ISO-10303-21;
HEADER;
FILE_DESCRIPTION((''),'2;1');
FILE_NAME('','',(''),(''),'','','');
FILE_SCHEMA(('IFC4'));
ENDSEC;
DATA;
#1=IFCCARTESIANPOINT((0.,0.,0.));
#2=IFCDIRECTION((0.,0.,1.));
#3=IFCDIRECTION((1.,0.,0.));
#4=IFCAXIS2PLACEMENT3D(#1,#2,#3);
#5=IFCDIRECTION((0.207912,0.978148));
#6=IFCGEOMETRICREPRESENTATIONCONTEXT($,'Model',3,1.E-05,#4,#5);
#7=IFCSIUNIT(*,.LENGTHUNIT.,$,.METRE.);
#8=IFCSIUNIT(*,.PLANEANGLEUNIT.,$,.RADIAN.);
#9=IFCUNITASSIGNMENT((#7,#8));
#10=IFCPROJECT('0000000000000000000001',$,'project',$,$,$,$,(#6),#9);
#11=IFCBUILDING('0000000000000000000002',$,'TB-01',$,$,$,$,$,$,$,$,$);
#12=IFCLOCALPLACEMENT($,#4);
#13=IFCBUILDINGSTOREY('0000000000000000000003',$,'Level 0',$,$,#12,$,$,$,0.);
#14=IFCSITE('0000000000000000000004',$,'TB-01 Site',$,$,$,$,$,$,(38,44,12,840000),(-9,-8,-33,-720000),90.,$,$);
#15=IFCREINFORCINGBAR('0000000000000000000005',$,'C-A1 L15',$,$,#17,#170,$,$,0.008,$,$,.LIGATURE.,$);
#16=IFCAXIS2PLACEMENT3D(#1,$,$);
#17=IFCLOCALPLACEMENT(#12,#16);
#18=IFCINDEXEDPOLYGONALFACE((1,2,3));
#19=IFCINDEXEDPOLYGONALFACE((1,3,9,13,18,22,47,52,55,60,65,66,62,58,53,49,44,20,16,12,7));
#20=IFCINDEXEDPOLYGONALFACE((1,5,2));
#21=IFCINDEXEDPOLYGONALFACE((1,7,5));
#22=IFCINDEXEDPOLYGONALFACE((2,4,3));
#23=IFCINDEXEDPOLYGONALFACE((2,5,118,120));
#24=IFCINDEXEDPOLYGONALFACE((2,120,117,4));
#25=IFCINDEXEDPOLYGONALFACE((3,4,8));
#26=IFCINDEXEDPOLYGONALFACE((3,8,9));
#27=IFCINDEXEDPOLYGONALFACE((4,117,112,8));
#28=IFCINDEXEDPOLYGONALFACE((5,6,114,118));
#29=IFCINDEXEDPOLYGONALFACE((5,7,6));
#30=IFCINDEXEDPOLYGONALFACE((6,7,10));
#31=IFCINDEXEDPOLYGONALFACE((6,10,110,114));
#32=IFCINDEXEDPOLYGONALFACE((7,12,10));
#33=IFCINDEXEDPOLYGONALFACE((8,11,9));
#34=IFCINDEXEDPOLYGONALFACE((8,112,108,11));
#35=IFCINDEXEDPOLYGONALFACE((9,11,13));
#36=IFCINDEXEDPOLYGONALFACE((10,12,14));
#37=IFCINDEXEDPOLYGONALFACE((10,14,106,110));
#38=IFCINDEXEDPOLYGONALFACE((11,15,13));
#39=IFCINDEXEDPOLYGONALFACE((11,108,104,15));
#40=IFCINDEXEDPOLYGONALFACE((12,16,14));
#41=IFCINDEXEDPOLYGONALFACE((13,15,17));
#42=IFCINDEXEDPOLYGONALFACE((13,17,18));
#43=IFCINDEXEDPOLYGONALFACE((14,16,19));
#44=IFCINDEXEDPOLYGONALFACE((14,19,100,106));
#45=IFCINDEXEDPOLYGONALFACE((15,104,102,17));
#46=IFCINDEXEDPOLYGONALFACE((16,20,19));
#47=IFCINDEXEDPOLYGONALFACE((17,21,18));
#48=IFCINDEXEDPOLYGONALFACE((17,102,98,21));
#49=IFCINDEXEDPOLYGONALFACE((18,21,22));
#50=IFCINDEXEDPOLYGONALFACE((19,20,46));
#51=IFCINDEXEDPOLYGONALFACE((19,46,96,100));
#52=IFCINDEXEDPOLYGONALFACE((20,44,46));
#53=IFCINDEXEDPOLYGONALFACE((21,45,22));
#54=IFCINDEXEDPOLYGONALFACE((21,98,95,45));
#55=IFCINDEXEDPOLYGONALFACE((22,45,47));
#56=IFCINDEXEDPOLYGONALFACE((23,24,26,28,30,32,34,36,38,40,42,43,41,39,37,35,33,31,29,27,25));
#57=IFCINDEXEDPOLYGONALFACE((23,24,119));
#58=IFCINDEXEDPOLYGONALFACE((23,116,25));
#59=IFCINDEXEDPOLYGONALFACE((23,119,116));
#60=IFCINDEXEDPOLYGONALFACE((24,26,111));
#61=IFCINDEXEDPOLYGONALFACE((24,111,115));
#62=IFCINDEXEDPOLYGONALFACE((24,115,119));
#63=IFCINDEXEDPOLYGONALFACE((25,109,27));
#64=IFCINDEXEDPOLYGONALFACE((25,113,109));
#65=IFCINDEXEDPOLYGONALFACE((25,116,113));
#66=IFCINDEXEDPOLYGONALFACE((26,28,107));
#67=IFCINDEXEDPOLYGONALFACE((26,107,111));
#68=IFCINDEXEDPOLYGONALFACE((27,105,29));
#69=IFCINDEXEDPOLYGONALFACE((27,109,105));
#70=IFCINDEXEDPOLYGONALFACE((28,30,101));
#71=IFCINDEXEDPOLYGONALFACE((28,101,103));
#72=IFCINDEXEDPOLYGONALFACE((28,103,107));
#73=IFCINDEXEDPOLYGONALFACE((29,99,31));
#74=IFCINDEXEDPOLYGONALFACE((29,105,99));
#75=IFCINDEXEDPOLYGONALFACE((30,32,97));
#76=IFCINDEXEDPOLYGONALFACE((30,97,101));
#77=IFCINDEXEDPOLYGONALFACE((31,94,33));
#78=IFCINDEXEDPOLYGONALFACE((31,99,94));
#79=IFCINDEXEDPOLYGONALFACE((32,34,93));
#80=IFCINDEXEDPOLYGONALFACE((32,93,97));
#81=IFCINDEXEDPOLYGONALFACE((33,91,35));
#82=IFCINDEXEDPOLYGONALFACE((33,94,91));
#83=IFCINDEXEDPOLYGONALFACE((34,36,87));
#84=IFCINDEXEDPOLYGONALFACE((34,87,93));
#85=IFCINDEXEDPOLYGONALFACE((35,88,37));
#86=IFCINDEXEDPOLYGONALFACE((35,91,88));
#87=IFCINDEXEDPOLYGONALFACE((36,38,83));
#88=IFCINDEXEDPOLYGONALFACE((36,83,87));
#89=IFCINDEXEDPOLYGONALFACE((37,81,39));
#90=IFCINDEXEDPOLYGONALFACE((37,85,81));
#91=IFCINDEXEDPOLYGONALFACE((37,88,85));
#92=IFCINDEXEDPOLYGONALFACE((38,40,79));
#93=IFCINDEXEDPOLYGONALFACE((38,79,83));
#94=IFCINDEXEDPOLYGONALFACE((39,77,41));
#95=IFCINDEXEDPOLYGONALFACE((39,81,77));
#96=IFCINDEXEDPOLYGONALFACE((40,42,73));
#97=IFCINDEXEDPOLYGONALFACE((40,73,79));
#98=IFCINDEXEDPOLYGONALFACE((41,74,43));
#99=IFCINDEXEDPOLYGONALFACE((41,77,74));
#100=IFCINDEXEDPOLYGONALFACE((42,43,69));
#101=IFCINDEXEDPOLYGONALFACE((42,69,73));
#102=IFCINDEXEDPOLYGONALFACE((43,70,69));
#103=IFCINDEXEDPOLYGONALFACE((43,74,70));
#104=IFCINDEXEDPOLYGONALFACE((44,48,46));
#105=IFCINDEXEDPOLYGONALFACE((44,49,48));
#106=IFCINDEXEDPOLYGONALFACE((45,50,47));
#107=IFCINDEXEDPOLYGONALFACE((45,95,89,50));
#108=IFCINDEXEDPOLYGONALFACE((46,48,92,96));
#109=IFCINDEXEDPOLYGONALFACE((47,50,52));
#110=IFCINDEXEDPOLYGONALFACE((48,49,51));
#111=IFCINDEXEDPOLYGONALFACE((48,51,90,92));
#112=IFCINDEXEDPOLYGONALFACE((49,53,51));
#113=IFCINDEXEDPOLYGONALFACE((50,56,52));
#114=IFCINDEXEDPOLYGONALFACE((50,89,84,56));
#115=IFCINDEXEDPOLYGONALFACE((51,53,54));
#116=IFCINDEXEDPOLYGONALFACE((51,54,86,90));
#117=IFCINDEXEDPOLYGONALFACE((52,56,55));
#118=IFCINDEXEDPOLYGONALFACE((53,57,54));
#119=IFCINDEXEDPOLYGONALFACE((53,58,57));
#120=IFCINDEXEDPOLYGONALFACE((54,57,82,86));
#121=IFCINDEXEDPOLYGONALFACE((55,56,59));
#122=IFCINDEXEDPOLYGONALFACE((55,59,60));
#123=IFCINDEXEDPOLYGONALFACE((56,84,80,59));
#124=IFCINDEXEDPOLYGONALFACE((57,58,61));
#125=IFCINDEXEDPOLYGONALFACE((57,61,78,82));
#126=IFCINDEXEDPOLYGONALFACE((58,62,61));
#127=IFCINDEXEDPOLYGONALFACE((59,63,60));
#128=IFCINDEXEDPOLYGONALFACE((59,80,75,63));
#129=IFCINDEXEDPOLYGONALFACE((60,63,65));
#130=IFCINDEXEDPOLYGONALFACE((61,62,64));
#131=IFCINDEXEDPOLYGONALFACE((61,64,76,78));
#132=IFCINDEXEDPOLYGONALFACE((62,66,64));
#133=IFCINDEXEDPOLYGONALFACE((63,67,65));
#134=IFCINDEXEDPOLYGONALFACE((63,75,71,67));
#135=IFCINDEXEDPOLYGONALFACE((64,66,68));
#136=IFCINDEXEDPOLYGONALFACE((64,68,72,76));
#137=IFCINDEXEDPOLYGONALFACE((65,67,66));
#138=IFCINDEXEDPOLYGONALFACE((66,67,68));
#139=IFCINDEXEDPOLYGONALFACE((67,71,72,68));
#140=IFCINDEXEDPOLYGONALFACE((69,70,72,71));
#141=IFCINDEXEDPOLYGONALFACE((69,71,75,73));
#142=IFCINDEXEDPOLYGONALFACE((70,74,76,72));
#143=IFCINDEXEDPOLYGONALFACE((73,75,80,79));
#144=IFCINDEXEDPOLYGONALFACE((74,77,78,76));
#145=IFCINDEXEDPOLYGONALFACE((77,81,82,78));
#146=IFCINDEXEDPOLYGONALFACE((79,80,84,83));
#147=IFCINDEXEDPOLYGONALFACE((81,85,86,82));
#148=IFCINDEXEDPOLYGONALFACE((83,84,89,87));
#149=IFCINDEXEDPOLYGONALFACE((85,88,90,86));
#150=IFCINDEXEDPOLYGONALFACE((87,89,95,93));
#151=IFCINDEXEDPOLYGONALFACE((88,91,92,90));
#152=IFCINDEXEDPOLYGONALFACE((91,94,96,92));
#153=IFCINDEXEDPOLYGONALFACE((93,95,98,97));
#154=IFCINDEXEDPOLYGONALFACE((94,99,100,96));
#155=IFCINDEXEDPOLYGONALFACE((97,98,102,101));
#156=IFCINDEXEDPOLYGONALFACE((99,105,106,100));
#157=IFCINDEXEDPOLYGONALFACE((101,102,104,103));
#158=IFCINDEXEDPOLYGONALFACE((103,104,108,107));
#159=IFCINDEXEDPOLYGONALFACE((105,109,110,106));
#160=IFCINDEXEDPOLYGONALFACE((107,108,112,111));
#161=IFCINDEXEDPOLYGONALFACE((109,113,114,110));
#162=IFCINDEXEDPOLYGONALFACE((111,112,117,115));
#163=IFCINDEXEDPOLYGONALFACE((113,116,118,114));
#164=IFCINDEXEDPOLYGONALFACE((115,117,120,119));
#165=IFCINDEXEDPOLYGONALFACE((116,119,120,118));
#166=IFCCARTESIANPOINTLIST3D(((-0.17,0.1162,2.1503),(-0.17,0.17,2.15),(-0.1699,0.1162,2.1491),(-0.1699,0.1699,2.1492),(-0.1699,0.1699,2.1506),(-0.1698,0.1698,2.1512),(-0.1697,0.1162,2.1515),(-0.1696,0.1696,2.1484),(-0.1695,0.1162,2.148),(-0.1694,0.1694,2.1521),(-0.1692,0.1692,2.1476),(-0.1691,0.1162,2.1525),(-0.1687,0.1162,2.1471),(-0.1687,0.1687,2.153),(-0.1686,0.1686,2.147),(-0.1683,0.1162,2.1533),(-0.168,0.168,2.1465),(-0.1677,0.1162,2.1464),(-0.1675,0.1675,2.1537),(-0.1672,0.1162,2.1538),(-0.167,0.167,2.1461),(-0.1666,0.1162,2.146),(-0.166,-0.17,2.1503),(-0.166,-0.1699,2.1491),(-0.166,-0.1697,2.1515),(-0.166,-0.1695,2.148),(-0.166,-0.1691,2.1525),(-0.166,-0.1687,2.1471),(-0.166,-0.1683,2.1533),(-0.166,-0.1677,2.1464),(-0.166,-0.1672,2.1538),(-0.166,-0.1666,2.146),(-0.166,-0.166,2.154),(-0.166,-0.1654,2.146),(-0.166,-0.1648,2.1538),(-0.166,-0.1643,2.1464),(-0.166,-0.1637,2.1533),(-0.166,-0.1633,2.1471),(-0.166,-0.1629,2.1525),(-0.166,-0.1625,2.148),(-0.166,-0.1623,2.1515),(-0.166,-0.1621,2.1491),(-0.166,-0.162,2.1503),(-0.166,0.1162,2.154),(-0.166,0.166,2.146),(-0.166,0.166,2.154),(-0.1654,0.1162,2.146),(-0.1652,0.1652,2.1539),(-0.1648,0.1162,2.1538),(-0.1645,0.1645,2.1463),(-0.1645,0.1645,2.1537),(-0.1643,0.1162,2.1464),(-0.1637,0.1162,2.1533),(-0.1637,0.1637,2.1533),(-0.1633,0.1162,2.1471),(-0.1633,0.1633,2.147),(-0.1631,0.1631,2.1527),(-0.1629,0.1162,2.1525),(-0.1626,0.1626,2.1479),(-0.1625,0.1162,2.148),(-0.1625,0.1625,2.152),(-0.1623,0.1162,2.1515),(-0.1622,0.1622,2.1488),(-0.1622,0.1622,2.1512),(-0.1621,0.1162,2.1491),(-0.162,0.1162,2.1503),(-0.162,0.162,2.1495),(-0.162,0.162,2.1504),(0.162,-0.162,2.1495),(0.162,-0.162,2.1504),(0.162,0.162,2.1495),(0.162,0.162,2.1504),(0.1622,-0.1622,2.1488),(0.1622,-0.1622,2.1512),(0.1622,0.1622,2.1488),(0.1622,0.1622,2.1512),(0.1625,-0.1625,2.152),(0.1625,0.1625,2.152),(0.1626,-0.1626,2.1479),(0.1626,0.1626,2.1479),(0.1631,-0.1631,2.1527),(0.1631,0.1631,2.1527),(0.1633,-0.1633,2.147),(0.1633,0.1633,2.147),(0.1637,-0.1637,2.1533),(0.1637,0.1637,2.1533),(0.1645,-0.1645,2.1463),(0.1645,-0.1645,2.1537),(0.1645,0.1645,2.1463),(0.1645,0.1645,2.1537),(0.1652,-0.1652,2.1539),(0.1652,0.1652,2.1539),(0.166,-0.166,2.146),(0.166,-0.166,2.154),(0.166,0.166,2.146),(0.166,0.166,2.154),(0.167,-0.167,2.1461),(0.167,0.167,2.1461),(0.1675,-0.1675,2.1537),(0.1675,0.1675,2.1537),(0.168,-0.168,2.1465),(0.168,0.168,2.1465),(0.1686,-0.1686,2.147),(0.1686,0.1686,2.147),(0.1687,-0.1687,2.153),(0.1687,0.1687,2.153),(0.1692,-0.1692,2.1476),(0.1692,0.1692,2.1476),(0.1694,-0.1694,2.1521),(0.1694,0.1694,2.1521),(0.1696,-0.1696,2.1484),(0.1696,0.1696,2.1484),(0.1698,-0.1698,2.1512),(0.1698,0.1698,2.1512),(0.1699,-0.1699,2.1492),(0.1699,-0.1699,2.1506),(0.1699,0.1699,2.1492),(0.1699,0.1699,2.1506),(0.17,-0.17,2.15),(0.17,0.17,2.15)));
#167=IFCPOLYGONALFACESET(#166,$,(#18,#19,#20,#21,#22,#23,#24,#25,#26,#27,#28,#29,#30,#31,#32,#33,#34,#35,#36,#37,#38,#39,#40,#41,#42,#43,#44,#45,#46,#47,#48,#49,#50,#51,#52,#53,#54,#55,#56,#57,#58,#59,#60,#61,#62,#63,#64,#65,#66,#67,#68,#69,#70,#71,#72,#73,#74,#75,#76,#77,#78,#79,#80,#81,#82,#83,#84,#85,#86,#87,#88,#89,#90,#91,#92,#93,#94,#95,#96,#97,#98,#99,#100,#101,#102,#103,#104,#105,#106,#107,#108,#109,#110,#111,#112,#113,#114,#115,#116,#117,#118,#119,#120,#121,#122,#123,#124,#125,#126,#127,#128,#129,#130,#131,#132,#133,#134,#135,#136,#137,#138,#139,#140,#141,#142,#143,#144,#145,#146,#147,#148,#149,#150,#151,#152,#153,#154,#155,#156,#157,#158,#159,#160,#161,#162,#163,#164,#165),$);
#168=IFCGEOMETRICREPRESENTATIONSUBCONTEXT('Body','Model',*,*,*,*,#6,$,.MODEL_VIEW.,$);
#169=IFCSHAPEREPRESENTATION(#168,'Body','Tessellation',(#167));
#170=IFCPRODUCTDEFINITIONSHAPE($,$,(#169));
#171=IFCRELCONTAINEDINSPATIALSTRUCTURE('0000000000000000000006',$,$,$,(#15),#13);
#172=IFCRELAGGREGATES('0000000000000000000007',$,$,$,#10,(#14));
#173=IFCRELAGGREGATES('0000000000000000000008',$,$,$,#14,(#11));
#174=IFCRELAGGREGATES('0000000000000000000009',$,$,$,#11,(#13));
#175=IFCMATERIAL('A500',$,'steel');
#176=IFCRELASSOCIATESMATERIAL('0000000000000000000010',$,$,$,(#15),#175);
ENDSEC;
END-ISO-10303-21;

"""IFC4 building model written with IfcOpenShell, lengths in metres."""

from ifc_helpers import new_model, entity, si_unit, direction, origin_with_axes, place, context, subcontext, project, spatial, material, element, save


model = new_model("IFC4")

# Units and contexts
model_context = context("Model", 3, precision=1e-05, world=origin_with_axes(), true_north=direction((0.207912, 0.978148)))
body_context = subcontext(model_context, "Body", "Model", "MODEL_VIEW")
ifc_project = project(units=[si_unit("LENGTHUNIT", "METRE"), si_unit("PLANEANGLEUNIT", "RADIAN")], contexts=[model_context])

# Site, building, storey
site = spatial("IfcSite", under=ifc_project, Name="TB-01 Site", RefLatitude=(38, 44, 12, 840000), RefLongitude=(-9, -8, -33, -720000), RefElevation=90.0)
building = spatial("IfcBuilding", under=site, Name="TB-01")
storey_placement = place(None, origin_with_axes())
storey = spatial("IfcBuildingStorey", under=building, at=storey_placement, Name="Level 0", Elevation=0.0)

# Reinforcing bar
ifc_material_1 = material(Name="A500", Category="steel")
reinforcing_bar_1_placement = place(storey_placement, origin_with_axes())
element("IfcReinforcingBar", 1, at=reinforcing_bar_1_placement, inside=storey, material=ifc_material_1, Name="C-A1 L15", NominalDiameter=0.008, PredefinedType="LIGATURE", context=body_context, shape_type="AdvancedSweptSolid", body=[
    entity("IfcSweptDiskSolid", entity("IfcPolyline", [entity("IfcCartesianPoint", [-0.166, -0.166, 2.15]), entity("IfcCartesianPoint", [0.166, -0.166, 2.15]), entity("IfcCartesianPoint", [0.166, 0.166, 2.15]), entity("IfcCartesianPoint", [-0.166, 0.166, 2.15]), entity("IfcCartesianPoint", [-0.166, 0.1162, 2.15])]), 0.004),
])

save(model, "model.ifc")
